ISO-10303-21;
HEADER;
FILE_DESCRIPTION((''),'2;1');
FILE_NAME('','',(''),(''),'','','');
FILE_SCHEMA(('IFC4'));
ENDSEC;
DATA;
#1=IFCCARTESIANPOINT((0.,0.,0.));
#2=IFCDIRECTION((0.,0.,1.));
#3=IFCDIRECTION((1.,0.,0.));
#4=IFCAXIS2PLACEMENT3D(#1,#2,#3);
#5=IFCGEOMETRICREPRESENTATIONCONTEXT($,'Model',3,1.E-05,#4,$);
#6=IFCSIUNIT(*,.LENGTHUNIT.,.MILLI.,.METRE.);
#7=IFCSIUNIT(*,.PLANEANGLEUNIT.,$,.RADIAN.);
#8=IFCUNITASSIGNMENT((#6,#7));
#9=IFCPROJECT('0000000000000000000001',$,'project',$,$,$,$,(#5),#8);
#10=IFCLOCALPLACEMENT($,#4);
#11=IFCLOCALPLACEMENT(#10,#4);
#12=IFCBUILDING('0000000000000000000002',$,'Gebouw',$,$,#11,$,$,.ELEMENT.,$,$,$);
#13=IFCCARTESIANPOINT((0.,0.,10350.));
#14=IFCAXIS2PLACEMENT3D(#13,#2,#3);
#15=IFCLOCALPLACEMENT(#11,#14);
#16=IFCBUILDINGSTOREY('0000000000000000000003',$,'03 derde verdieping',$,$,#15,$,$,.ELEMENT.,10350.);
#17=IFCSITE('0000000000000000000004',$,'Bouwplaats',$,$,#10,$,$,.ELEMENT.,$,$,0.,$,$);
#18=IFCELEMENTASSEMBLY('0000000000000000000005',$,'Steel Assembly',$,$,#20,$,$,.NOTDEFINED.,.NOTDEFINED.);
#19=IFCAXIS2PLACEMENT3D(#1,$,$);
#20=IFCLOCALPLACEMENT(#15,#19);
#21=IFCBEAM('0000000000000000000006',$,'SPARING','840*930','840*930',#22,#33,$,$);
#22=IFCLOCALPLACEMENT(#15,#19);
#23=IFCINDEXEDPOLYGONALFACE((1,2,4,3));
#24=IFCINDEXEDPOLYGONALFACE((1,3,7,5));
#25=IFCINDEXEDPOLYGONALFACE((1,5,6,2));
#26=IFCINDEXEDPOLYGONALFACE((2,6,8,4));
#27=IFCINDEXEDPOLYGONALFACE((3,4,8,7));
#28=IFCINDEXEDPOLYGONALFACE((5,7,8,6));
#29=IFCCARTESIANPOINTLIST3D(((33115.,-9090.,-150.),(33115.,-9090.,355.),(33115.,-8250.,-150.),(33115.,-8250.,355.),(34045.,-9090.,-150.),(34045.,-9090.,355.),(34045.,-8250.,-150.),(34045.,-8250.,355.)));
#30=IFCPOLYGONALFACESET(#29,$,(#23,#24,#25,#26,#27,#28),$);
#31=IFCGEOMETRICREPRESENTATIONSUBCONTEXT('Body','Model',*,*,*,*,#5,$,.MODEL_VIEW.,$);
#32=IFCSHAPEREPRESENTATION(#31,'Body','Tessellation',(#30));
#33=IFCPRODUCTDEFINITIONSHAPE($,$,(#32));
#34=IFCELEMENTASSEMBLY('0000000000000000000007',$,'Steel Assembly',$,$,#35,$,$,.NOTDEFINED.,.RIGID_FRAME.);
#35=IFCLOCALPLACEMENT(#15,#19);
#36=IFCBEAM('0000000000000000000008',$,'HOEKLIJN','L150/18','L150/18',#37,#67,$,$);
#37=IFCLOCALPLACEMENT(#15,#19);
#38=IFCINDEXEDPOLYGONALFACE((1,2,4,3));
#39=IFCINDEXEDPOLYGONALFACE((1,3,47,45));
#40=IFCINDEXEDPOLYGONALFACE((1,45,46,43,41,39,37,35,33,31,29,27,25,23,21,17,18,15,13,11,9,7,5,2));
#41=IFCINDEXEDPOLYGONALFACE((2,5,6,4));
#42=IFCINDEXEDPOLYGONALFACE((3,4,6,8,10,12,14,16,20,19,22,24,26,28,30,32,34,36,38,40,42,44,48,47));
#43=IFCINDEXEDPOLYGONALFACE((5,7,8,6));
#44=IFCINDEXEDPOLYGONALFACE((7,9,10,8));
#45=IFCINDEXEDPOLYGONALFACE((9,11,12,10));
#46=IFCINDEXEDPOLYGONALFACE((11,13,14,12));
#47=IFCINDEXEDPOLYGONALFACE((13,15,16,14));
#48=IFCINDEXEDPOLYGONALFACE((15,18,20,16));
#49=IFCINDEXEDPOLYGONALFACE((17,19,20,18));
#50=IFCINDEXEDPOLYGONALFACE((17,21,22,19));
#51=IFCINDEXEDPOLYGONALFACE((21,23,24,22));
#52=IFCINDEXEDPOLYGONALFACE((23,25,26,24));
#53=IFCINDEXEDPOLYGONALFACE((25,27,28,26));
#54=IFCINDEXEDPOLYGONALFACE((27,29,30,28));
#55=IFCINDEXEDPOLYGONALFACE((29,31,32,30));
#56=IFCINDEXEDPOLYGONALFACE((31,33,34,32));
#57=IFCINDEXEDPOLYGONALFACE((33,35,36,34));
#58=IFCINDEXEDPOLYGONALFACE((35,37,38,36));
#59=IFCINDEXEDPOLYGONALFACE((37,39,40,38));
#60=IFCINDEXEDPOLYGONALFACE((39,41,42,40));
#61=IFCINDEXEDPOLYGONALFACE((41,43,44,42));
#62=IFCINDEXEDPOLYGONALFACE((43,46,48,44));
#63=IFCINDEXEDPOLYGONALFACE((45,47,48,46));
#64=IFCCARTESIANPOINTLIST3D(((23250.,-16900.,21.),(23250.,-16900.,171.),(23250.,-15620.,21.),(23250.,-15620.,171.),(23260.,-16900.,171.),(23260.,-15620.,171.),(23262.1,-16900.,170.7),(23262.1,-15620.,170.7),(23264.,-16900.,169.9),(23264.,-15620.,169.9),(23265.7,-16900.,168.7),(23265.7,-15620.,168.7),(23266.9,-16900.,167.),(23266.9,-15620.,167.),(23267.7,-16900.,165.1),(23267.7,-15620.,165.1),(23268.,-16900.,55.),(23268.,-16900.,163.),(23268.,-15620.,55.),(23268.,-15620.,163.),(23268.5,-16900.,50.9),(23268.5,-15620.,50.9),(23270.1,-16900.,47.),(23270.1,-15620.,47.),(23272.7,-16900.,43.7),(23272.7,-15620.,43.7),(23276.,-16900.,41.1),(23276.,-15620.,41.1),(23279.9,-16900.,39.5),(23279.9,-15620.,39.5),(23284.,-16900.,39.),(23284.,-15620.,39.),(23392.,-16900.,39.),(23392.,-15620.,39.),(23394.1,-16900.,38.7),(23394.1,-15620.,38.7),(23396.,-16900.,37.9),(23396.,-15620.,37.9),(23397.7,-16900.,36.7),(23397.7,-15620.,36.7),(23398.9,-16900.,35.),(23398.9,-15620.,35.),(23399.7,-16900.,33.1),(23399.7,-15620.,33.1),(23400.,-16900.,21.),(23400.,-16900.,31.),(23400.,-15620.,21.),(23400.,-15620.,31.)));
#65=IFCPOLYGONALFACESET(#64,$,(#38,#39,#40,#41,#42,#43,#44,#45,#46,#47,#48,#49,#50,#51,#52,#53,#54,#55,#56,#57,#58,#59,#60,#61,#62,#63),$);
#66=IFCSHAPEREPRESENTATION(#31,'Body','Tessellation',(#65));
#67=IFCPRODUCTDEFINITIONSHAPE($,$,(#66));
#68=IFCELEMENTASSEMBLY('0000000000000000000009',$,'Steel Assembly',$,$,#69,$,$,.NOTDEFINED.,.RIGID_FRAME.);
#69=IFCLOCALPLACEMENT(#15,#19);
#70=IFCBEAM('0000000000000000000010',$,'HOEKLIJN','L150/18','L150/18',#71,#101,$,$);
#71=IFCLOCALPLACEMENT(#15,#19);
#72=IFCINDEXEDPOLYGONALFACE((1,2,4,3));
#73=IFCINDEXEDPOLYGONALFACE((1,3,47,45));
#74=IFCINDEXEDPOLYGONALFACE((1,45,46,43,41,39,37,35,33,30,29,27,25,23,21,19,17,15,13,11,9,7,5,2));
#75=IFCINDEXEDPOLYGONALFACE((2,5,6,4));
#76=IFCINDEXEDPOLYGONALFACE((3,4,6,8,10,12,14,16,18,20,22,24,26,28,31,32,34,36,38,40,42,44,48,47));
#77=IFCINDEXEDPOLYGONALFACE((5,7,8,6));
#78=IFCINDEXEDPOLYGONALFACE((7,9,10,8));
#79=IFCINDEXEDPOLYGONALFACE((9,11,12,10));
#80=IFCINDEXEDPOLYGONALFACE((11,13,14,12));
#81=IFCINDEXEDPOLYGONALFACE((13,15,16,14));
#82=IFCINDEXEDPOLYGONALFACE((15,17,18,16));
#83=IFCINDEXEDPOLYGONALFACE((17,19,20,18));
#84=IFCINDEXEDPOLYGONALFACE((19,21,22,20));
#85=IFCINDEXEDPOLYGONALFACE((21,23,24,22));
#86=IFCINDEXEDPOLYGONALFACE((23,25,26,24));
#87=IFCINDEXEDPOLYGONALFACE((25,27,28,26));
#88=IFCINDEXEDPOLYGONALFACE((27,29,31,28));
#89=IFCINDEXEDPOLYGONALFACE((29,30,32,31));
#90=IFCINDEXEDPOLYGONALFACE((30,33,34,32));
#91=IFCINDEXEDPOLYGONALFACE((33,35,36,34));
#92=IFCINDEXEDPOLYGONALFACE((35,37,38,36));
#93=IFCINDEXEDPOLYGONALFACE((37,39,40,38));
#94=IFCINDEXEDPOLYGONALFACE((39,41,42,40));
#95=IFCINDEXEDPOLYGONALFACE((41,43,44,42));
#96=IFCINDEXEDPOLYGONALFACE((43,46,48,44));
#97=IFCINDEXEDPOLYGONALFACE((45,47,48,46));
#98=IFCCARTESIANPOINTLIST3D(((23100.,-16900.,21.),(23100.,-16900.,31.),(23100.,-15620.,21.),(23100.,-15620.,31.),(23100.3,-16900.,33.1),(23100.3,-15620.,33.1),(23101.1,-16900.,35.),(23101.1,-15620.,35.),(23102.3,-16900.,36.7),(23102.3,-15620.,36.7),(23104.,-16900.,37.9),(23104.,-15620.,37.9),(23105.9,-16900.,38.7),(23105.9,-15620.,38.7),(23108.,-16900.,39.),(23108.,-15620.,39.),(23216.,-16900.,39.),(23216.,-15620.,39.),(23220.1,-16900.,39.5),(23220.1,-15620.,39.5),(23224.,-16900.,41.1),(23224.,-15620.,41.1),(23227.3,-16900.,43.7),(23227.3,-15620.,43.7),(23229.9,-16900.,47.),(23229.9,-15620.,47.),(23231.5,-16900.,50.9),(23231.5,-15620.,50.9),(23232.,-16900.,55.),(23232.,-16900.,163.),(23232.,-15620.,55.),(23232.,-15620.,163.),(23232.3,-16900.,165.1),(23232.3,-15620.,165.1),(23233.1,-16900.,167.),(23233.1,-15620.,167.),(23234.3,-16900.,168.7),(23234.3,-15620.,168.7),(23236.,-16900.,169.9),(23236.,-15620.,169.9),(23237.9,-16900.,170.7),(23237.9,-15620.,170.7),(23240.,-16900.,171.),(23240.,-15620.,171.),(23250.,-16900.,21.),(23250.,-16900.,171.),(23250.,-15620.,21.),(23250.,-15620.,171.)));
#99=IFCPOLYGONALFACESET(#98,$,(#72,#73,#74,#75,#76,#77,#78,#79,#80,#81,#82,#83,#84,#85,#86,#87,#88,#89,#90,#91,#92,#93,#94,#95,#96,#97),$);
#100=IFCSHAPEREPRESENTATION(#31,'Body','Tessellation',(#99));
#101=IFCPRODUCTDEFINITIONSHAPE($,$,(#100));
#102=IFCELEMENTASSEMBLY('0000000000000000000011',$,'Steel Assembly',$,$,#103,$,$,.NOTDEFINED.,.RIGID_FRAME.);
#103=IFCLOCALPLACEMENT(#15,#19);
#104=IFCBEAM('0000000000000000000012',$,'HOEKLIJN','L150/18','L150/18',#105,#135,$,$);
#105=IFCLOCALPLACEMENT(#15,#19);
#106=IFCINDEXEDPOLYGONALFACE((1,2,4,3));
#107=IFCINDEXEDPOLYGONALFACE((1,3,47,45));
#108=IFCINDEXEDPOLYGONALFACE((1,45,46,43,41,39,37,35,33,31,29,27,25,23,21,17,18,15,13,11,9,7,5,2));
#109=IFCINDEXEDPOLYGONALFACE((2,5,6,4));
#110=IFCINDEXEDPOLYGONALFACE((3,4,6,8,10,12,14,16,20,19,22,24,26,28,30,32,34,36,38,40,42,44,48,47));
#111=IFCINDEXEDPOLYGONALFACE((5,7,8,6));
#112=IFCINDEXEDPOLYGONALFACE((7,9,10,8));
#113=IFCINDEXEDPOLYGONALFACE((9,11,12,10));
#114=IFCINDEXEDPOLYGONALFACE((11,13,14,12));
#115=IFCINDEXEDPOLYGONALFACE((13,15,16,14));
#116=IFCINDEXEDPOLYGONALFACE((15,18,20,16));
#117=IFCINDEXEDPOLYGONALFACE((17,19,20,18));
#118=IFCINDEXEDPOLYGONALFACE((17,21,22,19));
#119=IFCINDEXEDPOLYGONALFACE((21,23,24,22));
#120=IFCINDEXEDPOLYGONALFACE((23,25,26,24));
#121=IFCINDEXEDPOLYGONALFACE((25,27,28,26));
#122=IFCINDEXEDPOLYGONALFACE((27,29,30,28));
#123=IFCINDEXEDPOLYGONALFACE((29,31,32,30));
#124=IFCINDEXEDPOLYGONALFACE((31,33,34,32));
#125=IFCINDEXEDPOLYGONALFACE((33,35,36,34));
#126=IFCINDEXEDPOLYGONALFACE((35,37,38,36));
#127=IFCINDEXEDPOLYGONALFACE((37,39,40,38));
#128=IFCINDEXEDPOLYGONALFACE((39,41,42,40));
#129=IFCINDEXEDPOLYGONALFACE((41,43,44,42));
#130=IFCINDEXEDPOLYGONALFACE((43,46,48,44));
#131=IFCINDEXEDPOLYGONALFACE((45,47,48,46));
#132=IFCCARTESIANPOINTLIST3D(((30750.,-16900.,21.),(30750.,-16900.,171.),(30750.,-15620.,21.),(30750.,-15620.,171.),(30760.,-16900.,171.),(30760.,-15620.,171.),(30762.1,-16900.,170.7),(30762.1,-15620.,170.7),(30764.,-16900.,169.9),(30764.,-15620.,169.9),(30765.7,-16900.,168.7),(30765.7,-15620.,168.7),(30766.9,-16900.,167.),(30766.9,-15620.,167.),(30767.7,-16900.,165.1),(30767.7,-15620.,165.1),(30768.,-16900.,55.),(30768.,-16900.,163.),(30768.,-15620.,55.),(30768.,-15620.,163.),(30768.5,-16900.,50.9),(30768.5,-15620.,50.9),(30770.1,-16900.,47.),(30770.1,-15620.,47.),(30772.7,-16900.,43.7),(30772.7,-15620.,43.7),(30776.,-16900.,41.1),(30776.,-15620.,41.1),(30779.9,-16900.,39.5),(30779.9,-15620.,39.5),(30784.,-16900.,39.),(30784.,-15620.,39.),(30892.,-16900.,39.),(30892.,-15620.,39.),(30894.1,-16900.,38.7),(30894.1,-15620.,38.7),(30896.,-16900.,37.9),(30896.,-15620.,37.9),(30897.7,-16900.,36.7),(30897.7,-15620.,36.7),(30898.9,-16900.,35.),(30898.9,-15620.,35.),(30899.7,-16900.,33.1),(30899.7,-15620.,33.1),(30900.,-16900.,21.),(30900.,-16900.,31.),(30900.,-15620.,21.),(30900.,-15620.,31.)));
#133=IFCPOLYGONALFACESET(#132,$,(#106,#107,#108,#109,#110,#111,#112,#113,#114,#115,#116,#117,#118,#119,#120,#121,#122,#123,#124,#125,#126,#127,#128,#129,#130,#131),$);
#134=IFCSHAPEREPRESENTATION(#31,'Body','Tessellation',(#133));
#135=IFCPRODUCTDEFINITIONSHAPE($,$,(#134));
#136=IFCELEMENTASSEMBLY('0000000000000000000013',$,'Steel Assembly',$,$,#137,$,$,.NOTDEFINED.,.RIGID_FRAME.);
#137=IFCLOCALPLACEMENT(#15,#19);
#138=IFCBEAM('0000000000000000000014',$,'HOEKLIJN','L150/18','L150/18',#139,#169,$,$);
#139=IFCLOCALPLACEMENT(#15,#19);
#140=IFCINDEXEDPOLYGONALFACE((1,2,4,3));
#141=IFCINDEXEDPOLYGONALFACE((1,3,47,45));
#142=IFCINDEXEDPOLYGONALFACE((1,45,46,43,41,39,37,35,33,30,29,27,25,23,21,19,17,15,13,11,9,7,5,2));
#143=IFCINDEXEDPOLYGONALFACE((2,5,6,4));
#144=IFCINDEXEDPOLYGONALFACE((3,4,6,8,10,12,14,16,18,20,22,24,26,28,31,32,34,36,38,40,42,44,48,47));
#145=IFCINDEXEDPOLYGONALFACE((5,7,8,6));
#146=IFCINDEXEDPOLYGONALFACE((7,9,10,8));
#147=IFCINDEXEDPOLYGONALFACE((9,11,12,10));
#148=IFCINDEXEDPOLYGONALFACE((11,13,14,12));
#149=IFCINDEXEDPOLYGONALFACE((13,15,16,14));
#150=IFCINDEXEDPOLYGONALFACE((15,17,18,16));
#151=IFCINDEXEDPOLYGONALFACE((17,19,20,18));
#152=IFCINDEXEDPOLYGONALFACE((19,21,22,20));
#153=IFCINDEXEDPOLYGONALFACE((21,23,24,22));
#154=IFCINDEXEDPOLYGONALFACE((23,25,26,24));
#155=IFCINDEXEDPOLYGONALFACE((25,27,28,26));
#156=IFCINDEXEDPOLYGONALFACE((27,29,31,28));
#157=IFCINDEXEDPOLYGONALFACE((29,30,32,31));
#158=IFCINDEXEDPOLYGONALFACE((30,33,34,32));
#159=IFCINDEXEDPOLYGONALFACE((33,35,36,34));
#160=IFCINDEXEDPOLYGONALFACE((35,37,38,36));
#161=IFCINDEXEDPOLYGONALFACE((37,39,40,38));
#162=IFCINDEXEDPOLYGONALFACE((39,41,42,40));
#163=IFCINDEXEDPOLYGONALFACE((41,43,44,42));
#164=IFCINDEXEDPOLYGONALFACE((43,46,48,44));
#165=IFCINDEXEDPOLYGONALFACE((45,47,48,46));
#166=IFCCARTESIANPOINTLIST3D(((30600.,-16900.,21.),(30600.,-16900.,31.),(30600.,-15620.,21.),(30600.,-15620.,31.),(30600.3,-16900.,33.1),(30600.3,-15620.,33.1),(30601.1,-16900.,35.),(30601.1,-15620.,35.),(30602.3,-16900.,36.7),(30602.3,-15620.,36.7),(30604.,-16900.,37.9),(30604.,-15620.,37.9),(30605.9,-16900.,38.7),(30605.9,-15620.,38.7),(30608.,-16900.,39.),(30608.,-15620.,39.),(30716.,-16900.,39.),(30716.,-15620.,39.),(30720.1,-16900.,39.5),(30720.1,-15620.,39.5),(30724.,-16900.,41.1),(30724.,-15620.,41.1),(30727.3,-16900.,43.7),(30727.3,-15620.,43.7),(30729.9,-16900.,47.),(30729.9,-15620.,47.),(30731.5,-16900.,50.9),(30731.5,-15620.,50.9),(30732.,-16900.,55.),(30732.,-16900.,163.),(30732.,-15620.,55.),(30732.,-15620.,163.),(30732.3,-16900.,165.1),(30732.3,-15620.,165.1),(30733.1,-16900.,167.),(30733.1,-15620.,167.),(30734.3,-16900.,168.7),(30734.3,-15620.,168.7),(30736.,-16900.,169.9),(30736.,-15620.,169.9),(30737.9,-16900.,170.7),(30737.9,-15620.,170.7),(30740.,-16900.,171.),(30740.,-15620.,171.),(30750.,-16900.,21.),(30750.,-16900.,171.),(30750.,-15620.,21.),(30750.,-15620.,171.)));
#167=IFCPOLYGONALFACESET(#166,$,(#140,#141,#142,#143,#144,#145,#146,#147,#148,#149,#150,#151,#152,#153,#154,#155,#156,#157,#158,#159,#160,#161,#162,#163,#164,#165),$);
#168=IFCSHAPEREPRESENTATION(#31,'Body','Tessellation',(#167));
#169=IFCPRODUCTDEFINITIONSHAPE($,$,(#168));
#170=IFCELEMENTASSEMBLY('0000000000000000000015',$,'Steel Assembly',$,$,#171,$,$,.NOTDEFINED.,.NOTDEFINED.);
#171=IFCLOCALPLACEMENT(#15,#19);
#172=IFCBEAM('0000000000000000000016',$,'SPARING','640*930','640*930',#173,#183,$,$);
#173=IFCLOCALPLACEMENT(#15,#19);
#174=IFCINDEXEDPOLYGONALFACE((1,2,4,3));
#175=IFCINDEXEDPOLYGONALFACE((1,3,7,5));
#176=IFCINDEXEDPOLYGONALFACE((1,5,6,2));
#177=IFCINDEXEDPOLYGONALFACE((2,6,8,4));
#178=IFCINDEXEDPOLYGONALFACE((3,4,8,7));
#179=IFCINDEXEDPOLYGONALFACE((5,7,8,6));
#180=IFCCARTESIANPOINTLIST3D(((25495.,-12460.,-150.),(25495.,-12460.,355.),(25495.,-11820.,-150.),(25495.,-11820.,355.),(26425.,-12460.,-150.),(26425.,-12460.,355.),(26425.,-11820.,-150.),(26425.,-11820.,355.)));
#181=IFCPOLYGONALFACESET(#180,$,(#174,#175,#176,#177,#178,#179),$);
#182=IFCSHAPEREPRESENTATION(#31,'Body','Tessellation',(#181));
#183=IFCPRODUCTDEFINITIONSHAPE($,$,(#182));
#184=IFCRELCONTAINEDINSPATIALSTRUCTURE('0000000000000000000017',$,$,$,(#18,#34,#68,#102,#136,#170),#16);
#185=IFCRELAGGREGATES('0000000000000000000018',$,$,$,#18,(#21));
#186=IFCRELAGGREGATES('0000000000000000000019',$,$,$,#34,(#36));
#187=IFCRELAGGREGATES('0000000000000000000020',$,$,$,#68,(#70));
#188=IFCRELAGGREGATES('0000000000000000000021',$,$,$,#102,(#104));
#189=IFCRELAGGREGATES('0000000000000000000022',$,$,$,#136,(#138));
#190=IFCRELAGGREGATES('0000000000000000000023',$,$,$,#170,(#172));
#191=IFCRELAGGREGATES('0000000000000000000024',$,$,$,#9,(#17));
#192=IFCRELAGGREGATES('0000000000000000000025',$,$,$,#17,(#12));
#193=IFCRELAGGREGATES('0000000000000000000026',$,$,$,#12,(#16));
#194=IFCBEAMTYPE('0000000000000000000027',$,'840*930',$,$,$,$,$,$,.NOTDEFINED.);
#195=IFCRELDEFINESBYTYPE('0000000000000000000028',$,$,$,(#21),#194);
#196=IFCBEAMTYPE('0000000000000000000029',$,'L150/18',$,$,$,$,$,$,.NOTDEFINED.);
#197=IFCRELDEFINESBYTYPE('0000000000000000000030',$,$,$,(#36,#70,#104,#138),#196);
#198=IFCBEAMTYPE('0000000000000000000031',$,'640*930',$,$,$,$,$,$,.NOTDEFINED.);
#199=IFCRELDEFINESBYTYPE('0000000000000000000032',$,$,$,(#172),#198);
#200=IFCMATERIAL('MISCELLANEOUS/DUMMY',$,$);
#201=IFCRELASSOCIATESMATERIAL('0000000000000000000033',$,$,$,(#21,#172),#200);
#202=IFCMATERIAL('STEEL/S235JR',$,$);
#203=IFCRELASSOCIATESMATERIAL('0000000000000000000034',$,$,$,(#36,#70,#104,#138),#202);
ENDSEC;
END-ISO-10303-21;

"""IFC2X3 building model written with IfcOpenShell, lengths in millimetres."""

from ifc_helpers import new_model, si_unit, frame, origin_with_axes, origin_2d_with_axis, place, context, subcontext, project, spatial, rectangle, l_section, extrude, material, type_object, element, aggregate, save


model = new_model("IFC2X3")

# Units and contexts
model_context = context("Model", 3, precision=1e-05, world=origin_with_axes())
body_context = subcontext(model_context, "Body", "Model", "MODEL_VIEW")
ifc_project = project(units=[si_unit("LENGTHUNIT", "METRE", prefix="MILLI"), si_unit("PLANEANGLEUNIT", "RADIAN")], contexts=[model_context])

# Site, building, storey
site_placement = place(None, origin_with_axes())
site = spatial("IfcSite", under=ifc_project, at=site_placement, Name="Bouwplaats", CompositionType="ELEMENT", RefElevation=0.0)
building_placement = place(site_placement, origin_with_axes())
building = spatial("IfcBuilding", under=site, at=building_placement, Name="Gebouw", CompositionType="ELEMENT")
storey_placement = place(building_placement, frame((0.0, 0.0, 10350.0), z_axis=(0.0, 0.0, 1.0), x_axis=(1.0, 0.0, 0.0)))
storey = spatial("IfcBuildingStorey", under=building, at=storey_placement, Name="03 derde verdieping", CompositionType="ELEMENT", Elevation=10350.0)

# Shared definitions
ifc_material_1 = material(Name="STEEL/S235JR")

# Element assemblies, beams
ifc_material_2 = material(Name="MISCELLANEOUS/DUMMY")
assembly_1_placement = place(storey_placement, origin_with_axes())
assembly_1 = element("IfcElementAssembly", 1, at=assembly_1_placement, inside=storey, Name="Steel Assembly", AssemblyPlace="NOTDEFINED", PredefinedType="NOTDEFINED")
beam_type_1 = type_object("IfcBeamType", Name="840*930", PredefinedType="NOTDEFINED")
beam_1_placement = place(assembly_1_placement, frame((33580.0, -8670.0, 355.0), z_axis=(1.0, -0.000004, 0.0), x_axis=(0.0, 0.0, -1.0)))
beam_1 = element("IfcBeam", 2, at=beam_1_placement, type_object=beam_type_1, material=ifc_material_2, Name="SPARING", Description="840*930", ObjectType="840*930", context=body_context, shape_type="SweptSolid", body=[
    extrude(rectangle(XDim=840.0, YDim=930.0, at=origin_2d_with_axis()), frame((505.0, 0.0, 0.0), z_axis=(-1.0, 0.0, 0.0), x_axis=(0.0, -1.0, 0.0)), (0.0, 0.0, 1.0), 505.0),
])
aggregate(assembly_1, [beam_1])
assembly_2_placement = place(storey_placement, origin_with_axes())
assembly_2 = element("IfcElementAssembly", 3, at=assembly_2_placement, inside=storey, Name="Steel Assembly", AssemblyPlace="NOTDEFINED", PredefinedType="RIGID_FRAME")
beam_type_2 = type_object("IfcBeamType", Name="L150/18", PredefinedType="NOTDEFINED")
beam_2_placement = place(assembly_2_placement, frame((23325.0, -16900.0, 96.0), z_axis=(0.0, 0.0, 1.0), x_axis=(0.0, 1.0, 0.0)))
beam_2 = element("IfcBeam", 4, at=beam_2_placement, type_object=beam_type_2, material=ifc_material_1, Name="HOEKLIJN", Description="L150/18", ObjectType="L150/18", context=body_context, shape_type="SweptSolid", body=[
    extrude(l_section(Depth=150.0, Width=150.0, Thickness=18.0, FilletRadius=16.0, EdgeRadius=8.0, at=origin_2d_with_axis()), frame((1280.0, 0.0, 0.0), z_axis=(-1.0, 0.0, 0.0), x_axis=(0.0, -1.0, 0.0)), (0.0, 0.0, 1.0), 1280.0),
])
aggregate(assembly_2, [beam_2])
assembly_3_placement = place(storey_placement, origin_with_axes())
assembly_3 = element("IfcElementAssembly", 5, at=assembly_3_placement, inside=storey, Name="Steel Assembly", AssemblyPlace="NOTDEFINED", PredefinedType="RIGID_FRAME")
beam_3_placement = place(assembly_3_placement, frame((23175.0, -15620.0, 96.0), z_axis=(0.0, 0.0, 1.0), x_axis=(0.0, -1.0, 0.0)))
beam_3 = element("IfcBeam", 6, at=beam_3_placement, type_object=beam_type_2, material=ifc_material_1, Name="HOEKLIJN", Description="L150/18", ObjectType="L150/18", context=body_context, shape_type="SweptSolid", body=[
    extrude(l_section(Depth=150.0, Width=150.0, Thickness=18.0, FilletRadius=16.0, EdgeRadius=8.0, at=origin_2d_with_axis()), frame((1280.0, 0.0, 0.0), z_axis=(-1.0, 0.0, 0.0), x_axis=(0.0, -1.0, 0.0)), (0.0, 0.0, 1.0), 1280.0),
])
aggregate(assembly_3, [beam_3])
assembly_4_placement = place(storey_placement, origin_with_axes())
assembly_4 = element("IfcElementAssembly", 7, at=assembly_4_placement, inside=storey, Name="Steel Assembly", AssemblyPlace="NOTDEFINED", PredefinedType="RIGID_FRAME")
beam_4_placement = place(assembly_4_placement, frame((30825.0, -16900.0, 96.0), z_axis=(0.0, 0.0, 1.0), x_axis=(0.0, 1.0, 0.0)))
beam_4 = element("IfcBeam", 8, at=beam_4_placement, type_object=beam_type_2, material=ifc_material_1, Name="HOEKLIJN", Description="L150/18", ObjectType="L150/18", context=body_context, shape_type="SweptSolid", body=[
    extrude(l_section(Depth=150.0, Width=150.0, Thickness=18.0, FilletRadius=16.0, EdgeRadius=8.0, at=origin_2d_with_axis()), frame((1280.0, 0.0, 0.0), z_axis=(-1.0, 0.0, 0.0), x_axis=(0.0, -1.0, 0.0)), (0.0, 0.0, 1.0), 1280.0),
])
aggregate(assembly_4, [beam_4])
assembly_5_placement = place(storey_placement, origin_with_axes())
assembly_5 = element("IfcElementAssembly", 9, at=assembly_5_placement, inside=storey, Name="Steel Assembly", AssemblyPlace="NOTDEFINED", PredefinedType="RIGID_FRAME")
beam_5_placement = place(assembly_5_placement, frame((30675.0, -15620.0, 96.0), z_axis=(0.0, 0.0, 1.0), x_axis=(0.0, -1.0, 0.0)))
beam_5 = element("IfcBeam", 10, at=beam_5_placement, type_object=beam_type_2, material=ifc_material_1, Name="HOEKLIJN", Description="L150/18", ObjectType="L150/18", context=body_context, shape_type="SweptSolid", body=[
    extrude(l_section(Depth=150.0, Width=150.0, Thickness=18.0, FilletRadius=16.0, EdgeRadius=8.0, at=origin_2d_with_axis()), frame((1280.0, 0.0, 0.0), z_axis=(-1.0, 0.0, 0.0), x_axis=(0.0, -1.0, 0.0)), (0.0, 0.0, 1.0), 1280.0),
])
aggregate(assembly_5, [beam_5])
assembly_6_placement = place(storey_placement, origin_with_axes())
assembly_6 = element("IfcElementAssembly", 11, at=assembly_6_placement, inside=storey, Name="Steel Assembly", AssemblyPlace="NOTDEFINED", PredefinedType="NOTDEFINED")
beam_type_3 = type_object("IfcBeamType", Name="640*930", PredefinedType="NOTDEFINED")
beam_6_placement = place(assembly_6_placement, frame((25960.0, -12140.0, 355.0), z_axis=(1.0, -0.000004, 0.0), x_axis=(0.0, 0.0, -1.0)))
beam_6 = element("IfcBeam", 12, at=beam_6_placement, type_object=beam_type_3, material=ifc_material_2, Name="SPARING", Description="640*930", ObjectType="640*930", context=body_context, shape_type="SweptSolid", body=[
    extrude(rectangle(XDim=640.0, YDim=930.0, at=origin_2d_with_axis()), frame((505.0, 0.0, 0.0), z_axis=(-1.0, 0.0, 0.0), x_axis=(0.0, -1.0, 0.0)), (0.0, 0.0, 1.0), 505.0),
])
aggregate(assembly_6, [beam_6])

save(model, "model.ifc")
